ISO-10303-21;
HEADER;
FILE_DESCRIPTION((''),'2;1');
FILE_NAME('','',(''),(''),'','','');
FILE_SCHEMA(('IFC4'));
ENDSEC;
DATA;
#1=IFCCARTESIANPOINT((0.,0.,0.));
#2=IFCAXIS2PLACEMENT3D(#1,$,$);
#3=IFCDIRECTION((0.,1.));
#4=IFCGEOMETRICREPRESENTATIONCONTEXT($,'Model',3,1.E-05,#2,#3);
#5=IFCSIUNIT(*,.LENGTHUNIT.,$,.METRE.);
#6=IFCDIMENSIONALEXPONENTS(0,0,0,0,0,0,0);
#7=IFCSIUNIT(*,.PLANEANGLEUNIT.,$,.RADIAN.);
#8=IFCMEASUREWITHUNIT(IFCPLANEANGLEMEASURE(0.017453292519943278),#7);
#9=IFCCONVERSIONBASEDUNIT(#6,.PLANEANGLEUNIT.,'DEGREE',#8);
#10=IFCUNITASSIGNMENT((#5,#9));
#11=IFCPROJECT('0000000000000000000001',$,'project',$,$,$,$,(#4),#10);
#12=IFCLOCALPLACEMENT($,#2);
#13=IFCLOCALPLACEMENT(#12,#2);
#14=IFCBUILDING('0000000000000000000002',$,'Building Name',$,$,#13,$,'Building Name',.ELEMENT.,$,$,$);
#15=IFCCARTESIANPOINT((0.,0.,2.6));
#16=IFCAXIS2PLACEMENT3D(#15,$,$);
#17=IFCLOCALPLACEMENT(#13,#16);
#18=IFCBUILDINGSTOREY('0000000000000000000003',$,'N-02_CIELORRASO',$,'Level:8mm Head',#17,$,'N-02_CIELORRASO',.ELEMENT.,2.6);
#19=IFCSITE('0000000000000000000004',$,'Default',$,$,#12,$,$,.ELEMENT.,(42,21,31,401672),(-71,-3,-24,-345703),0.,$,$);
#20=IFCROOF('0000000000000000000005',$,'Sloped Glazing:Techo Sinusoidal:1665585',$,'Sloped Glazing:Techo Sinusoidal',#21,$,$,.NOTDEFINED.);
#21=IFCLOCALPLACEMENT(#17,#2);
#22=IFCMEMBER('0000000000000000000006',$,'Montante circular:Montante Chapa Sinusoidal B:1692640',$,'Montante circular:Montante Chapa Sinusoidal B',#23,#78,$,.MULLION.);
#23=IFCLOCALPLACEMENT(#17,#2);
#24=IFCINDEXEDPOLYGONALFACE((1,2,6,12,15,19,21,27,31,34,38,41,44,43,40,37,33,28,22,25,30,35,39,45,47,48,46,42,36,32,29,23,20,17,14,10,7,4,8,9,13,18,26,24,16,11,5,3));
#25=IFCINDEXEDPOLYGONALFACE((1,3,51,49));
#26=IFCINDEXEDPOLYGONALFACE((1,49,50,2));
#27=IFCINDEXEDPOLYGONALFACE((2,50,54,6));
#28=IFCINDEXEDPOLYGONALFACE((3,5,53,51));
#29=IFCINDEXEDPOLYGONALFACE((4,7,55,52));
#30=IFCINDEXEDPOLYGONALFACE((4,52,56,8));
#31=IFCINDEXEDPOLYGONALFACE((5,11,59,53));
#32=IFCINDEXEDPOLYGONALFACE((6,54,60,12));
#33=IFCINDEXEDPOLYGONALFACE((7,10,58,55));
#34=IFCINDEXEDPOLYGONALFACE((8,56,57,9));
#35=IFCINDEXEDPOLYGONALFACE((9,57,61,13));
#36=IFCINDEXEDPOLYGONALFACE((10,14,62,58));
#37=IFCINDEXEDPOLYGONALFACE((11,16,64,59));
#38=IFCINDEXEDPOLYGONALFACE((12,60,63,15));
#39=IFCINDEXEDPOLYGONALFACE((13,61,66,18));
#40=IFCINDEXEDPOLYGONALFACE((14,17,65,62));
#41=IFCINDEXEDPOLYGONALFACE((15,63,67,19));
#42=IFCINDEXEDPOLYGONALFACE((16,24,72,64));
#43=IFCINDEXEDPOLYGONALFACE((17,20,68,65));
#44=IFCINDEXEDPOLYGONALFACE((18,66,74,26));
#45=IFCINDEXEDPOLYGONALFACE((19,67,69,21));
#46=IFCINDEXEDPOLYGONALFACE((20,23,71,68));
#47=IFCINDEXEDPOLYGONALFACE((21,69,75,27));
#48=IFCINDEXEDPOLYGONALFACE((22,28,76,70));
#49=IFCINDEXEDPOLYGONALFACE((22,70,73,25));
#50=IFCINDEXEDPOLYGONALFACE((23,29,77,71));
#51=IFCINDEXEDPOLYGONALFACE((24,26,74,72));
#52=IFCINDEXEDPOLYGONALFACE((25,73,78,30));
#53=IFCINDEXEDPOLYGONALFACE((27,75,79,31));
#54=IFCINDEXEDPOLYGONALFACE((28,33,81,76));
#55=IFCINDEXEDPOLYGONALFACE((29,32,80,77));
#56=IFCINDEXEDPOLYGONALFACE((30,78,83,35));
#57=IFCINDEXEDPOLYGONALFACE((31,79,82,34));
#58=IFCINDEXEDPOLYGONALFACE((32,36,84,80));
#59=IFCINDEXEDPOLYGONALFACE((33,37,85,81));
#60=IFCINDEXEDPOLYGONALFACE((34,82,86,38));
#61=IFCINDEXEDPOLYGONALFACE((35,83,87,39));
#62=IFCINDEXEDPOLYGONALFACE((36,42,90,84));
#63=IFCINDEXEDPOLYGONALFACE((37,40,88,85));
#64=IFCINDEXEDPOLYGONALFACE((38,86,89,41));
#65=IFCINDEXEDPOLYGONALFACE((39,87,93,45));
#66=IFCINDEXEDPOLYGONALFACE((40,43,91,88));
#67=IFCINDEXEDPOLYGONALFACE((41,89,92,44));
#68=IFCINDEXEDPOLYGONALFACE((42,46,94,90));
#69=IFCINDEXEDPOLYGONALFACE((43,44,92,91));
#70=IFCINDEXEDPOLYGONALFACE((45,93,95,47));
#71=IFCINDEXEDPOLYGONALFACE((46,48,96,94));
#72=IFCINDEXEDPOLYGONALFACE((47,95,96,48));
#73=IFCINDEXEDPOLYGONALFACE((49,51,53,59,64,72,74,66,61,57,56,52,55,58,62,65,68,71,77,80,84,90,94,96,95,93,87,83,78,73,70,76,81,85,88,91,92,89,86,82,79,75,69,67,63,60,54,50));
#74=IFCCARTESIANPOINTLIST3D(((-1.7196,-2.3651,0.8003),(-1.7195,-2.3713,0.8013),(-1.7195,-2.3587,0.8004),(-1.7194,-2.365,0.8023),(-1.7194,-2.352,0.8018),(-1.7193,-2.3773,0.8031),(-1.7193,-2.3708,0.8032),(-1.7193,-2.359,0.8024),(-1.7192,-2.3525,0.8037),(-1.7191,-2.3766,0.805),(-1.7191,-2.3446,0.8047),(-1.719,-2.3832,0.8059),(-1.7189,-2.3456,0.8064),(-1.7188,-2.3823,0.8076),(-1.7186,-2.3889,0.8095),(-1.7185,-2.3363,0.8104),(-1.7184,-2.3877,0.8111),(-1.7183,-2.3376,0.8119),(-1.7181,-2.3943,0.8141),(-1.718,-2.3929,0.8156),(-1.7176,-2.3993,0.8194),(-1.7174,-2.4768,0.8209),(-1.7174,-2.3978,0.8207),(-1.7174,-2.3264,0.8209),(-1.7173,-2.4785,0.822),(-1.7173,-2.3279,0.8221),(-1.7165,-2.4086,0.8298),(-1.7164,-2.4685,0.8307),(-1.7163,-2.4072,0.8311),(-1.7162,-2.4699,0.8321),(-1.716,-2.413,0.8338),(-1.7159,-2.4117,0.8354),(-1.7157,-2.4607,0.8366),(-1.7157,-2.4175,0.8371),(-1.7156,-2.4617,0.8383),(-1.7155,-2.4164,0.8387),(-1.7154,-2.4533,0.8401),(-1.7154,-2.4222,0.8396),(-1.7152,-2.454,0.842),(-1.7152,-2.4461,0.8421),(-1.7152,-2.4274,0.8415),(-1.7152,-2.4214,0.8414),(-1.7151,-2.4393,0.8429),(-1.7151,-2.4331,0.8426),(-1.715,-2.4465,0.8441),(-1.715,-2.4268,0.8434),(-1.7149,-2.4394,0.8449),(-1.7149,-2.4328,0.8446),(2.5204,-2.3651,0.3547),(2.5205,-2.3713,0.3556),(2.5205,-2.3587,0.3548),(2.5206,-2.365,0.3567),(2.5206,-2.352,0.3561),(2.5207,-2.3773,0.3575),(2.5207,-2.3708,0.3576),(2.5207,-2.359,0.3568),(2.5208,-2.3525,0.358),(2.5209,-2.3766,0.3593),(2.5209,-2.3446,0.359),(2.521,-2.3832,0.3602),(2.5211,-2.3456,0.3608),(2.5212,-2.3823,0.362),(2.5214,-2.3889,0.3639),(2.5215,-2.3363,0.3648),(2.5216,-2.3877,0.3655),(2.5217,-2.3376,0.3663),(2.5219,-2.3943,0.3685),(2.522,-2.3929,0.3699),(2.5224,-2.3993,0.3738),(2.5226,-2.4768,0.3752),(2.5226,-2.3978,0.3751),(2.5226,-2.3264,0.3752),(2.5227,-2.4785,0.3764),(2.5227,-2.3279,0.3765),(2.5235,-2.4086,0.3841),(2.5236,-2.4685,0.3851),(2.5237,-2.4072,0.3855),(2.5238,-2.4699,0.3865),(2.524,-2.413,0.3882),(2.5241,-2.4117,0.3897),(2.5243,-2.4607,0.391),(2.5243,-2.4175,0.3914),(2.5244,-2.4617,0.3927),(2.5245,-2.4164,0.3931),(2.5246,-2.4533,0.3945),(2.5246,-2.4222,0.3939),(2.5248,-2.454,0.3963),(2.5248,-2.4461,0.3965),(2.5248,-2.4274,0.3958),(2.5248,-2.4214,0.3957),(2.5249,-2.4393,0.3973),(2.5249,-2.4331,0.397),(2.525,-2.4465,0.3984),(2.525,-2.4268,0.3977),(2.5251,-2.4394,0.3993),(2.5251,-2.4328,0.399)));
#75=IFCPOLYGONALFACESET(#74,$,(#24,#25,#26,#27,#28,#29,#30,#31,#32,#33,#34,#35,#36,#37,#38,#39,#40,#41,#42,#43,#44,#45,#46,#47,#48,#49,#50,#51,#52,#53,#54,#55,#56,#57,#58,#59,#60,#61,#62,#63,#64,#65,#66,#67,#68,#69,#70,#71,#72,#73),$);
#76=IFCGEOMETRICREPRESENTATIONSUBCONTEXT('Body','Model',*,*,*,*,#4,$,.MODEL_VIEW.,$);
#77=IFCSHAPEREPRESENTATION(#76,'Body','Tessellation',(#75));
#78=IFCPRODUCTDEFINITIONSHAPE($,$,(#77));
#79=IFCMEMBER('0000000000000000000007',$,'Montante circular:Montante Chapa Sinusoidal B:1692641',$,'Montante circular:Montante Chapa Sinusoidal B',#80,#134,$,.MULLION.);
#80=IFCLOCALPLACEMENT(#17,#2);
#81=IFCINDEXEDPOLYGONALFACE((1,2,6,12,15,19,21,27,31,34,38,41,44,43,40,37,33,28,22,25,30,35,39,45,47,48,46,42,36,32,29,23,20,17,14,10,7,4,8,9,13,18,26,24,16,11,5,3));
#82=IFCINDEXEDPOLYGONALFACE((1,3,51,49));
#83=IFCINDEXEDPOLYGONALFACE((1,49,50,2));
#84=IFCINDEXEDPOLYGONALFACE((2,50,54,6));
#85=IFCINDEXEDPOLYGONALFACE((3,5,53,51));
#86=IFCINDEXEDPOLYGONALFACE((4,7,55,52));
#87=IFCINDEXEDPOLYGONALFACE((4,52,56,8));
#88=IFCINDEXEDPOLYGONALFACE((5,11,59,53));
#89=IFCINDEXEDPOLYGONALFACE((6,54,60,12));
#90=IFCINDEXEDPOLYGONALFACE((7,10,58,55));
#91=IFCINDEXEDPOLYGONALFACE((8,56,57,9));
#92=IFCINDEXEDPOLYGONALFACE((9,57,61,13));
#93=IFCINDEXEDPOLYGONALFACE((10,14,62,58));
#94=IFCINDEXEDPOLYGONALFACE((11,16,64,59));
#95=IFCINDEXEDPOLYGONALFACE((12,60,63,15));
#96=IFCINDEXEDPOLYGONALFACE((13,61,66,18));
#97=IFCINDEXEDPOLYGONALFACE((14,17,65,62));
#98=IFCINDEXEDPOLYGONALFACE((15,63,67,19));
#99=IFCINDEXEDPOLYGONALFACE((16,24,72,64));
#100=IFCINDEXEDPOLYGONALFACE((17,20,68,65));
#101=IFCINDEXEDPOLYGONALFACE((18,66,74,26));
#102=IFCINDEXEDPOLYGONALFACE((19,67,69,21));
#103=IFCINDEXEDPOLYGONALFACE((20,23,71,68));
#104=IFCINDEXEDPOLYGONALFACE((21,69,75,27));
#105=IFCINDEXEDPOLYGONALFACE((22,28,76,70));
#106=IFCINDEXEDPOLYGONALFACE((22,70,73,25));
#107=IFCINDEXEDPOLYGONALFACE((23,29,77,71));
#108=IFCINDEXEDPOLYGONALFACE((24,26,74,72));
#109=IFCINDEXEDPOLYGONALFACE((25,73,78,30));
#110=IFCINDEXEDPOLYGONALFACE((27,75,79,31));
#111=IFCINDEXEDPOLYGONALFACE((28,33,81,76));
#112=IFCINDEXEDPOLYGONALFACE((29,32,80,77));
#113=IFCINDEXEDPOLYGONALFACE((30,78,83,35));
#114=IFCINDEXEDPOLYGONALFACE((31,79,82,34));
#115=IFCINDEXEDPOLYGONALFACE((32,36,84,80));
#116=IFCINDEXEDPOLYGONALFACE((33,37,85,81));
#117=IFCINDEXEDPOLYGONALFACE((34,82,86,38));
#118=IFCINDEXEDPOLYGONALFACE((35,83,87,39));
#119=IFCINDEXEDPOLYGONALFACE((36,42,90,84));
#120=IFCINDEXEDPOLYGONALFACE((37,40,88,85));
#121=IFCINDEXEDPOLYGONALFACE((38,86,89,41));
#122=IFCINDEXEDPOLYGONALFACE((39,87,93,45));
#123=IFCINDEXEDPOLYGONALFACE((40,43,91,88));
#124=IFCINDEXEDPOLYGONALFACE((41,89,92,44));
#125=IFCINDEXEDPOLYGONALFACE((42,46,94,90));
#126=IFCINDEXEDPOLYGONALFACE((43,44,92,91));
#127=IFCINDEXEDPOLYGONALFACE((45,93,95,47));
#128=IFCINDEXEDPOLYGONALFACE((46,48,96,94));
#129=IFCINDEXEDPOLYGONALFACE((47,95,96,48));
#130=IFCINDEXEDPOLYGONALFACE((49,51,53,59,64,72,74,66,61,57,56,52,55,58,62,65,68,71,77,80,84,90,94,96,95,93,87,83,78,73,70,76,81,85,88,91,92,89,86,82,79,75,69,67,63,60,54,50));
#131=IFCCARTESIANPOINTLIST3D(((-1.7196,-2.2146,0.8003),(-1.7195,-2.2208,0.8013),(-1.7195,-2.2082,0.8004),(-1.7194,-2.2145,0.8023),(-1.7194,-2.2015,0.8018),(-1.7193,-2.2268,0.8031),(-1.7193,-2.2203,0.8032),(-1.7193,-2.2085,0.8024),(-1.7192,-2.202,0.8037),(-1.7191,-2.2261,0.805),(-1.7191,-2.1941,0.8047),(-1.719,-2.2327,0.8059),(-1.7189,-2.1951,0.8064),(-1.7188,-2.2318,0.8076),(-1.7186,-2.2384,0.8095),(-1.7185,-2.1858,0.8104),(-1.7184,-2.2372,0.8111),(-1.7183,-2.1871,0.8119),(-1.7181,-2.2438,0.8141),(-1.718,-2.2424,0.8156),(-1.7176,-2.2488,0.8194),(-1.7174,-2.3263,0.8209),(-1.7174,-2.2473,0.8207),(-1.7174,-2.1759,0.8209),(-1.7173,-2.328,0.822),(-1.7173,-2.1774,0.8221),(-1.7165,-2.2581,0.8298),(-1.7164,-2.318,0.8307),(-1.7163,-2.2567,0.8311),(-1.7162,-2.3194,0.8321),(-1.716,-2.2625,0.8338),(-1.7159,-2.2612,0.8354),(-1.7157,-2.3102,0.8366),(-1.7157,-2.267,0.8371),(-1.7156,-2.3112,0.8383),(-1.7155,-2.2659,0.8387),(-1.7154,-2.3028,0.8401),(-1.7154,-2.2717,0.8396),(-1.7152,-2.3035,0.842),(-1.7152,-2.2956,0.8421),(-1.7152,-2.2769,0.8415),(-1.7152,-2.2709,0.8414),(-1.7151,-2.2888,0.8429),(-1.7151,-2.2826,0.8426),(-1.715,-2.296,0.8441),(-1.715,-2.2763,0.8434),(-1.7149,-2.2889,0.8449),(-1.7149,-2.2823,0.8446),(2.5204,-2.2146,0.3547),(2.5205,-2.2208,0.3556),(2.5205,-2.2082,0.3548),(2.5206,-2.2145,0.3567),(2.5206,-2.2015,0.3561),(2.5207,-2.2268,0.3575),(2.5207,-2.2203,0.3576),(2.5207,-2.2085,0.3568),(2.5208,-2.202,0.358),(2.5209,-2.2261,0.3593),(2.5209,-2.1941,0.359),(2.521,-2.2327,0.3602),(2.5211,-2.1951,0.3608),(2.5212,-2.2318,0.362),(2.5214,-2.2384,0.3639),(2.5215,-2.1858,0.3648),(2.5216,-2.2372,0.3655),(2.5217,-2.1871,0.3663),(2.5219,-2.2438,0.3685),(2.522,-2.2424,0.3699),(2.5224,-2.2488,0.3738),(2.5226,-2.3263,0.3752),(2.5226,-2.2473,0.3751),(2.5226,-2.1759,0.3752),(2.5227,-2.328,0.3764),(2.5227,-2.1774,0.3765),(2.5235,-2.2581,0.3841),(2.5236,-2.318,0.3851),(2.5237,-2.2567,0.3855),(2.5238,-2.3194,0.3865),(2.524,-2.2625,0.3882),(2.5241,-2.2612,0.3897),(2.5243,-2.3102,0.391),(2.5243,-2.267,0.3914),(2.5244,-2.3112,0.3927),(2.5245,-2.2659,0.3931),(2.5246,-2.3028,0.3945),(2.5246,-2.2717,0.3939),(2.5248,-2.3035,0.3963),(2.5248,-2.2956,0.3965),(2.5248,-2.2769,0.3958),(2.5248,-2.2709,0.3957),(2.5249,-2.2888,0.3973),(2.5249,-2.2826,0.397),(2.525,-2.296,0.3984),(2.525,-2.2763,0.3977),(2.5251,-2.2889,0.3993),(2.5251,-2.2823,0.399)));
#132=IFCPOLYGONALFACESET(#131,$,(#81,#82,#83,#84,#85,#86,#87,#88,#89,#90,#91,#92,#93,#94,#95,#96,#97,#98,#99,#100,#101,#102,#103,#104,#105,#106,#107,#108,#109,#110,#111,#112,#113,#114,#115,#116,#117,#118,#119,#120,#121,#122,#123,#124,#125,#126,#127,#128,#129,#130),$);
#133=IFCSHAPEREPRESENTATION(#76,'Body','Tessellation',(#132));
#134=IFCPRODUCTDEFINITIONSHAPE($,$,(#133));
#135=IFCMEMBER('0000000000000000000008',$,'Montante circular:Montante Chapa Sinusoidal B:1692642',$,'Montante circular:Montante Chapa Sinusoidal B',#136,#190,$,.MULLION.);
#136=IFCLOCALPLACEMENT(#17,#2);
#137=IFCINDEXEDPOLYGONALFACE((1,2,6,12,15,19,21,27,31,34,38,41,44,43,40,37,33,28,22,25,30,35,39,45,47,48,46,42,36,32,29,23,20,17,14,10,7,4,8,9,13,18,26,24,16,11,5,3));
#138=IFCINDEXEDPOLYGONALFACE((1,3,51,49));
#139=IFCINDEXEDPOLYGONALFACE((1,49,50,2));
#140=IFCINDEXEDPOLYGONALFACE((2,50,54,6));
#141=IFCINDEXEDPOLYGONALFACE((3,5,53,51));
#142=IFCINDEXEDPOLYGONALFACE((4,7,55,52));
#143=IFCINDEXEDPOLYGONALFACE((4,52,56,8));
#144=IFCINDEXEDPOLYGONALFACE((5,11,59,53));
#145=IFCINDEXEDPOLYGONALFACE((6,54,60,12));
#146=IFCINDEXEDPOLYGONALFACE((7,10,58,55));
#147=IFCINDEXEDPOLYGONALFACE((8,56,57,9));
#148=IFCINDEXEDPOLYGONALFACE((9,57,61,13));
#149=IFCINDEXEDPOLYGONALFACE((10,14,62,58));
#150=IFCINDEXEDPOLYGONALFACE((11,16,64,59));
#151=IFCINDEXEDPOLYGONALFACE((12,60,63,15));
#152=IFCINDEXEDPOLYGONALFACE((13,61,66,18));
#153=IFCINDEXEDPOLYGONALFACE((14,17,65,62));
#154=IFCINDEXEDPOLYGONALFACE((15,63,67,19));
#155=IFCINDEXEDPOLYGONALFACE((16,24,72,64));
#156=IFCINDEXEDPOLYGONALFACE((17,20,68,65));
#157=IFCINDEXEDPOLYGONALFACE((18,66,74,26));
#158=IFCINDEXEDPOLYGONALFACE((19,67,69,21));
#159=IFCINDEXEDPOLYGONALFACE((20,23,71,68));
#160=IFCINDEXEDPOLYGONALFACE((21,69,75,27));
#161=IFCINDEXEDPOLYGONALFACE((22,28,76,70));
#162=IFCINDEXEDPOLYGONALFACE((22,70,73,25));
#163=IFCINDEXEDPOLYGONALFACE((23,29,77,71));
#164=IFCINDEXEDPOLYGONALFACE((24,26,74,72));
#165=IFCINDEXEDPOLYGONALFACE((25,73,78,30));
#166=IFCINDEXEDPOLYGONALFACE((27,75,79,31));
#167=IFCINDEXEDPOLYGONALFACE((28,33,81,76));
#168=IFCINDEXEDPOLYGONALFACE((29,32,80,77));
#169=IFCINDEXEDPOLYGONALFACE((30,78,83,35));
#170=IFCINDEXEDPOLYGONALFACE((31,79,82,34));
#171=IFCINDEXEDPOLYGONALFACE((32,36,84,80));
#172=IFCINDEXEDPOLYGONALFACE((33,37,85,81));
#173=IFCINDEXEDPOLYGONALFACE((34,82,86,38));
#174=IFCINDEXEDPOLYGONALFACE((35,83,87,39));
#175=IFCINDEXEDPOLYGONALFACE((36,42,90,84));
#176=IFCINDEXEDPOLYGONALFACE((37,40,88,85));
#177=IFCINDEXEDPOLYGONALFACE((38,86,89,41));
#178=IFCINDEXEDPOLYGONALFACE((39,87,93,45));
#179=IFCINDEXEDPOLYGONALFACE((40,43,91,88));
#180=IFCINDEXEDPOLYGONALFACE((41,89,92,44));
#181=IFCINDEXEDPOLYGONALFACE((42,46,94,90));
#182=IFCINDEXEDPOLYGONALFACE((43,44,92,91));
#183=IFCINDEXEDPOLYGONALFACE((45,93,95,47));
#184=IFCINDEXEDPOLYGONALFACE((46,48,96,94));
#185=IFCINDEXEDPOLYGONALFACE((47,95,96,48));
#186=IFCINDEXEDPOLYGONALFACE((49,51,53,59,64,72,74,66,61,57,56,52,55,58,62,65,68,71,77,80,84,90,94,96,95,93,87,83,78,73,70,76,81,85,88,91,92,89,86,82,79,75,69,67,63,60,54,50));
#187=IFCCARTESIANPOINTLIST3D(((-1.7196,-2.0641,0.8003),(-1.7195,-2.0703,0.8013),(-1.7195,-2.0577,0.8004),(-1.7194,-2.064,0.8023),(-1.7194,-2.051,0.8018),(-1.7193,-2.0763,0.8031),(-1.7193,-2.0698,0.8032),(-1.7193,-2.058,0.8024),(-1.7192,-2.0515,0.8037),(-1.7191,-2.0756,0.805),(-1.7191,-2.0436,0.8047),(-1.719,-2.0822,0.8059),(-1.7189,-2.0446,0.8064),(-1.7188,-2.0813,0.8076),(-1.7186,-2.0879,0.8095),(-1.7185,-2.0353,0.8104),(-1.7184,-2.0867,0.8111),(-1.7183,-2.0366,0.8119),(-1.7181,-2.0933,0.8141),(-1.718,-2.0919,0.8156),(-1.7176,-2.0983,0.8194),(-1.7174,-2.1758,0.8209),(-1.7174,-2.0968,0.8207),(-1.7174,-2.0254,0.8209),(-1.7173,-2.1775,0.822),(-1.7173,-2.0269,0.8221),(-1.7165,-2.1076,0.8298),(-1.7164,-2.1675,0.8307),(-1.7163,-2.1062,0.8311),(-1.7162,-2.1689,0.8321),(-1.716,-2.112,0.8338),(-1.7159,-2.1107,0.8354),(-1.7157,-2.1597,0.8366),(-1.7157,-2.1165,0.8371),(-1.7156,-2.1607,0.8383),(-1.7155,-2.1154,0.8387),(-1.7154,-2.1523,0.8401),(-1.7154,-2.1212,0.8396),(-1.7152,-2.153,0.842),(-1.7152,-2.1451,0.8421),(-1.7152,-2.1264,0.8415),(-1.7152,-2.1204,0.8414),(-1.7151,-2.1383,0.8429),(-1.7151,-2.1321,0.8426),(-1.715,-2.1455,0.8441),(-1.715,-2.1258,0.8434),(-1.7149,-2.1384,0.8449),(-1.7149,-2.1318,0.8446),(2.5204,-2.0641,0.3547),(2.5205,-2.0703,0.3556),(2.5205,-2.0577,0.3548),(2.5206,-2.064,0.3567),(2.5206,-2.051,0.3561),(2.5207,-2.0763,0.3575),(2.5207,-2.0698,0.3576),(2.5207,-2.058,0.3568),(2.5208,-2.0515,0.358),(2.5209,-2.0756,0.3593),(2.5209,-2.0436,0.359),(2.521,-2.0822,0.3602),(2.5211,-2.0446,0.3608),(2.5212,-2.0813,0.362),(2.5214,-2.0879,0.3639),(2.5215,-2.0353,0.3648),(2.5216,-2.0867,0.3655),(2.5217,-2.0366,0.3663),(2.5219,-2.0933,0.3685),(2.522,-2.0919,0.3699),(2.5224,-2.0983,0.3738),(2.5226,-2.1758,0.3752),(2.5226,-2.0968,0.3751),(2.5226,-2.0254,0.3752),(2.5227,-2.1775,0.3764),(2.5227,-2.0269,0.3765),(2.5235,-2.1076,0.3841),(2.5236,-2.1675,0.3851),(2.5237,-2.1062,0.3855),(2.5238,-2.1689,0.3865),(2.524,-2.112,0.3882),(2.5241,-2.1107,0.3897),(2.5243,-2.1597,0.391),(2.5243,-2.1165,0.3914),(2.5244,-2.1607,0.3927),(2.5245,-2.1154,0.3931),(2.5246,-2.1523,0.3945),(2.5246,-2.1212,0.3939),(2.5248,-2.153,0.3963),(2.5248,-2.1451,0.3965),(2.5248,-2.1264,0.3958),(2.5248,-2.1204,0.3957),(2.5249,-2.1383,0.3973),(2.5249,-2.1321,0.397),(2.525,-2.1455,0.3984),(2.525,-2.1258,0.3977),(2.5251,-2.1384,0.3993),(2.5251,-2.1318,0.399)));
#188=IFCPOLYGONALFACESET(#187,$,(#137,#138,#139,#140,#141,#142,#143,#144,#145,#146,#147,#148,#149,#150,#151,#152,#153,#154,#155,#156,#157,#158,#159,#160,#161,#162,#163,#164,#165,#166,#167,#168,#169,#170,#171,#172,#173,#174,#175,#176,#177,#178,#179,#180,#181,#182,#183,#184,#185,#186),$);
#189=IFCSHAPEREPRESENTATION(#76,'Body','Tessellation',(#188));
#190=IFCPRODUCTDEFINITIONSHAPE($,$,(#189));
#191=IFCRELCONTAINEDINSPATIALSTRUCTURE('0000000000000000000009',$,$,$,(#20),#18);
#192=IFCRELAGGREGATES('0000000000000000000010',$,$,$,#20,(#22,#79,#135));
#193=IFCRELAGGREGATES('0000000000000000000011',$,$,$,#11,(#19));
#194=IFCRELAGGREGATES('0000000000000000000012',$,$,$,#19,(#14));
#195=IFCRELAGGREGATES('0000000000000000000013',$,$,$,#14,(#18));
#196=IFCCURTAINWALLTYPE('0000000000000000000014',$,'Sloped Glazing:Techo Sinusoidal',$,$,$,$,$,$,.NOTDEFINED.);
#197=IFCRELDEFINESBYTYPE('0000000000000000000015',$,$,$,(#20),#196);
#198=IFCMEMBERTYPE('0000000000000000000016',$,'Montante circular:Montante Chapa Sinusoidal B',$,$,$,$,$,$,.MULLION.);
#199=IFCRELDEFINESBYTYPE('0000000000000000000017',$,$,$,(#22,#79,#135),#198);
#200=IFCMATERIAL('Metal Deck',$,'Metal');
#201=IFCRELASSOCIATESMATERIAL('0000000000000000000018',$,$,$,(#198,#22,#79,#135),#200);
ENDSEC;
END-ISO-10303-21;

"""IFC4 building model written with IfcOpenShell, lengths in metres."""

from ifc_helpers import new_model, entity, si_unit, converted_unit, direction, frame, origin, place, context, subcontext, project, spatial, indexed_curve, outline, extrude, source, transform, mapped, material, type_object, type_shapes, element, aggregate, save


model = new_model("IFC4")

# Units and contexts
model_context = context("Model", 3, precision=1e-05, world=origin(), true_north=direction((0.0, 1.0)))
body_context = subcontext(model_context, "Body", "Model", "MODEL_VIEW")
ifc_project = project(units=[si_unit("LENGTHUNIT", "METRE"), converted_unit("PLANEANGLEUNIT", "DEGREE", entity("IfcPlaneAngleMeasure", 0.017453292519943278), si_unit("PLANEANGLEUNIT", "RADIAN"), dimensions=[0, 0, 0, 0, 0, 0, 0])], contexts=[model_context])

# Site, building, storey
site_placement = place(None, origin())
site = spatial("IfcSite", under=ifc_project, at=site_placement, Name="Default", CompositionType="ELEMENT", RefLatitude=(42, 21, 31, 401672), RefLongitude=(-71, -3, -24, -345703), RefElevation=0.0)
building_placement = place(site_placement, origin())
building = spatial("IfcBuilding", under=site, at=building_placement, Name="Building Name", LongName="Building Name", CompositionType="ELEMENT")
storey_placement = place(building_placement, frame((0.0, 0.0, 2.6)))
storey = spatial("IfcBuildingStorey", under=building, at=storey_placement, Name="N-02_CIELORRASO", ObjectType="Level:8mm Head", LongName="N-02_CIELORRASO", CompositionType="ELEMENT", Elevation=2.6)

# Roof, members
curtain_wall_type = type_object("IfcCurtainWallType", Name="Sloped Glazing:Techo Sinusoidal", PredefinedType="NOTDEFINED")
roof_placement = place(storey_placement, frame((0.0, 0.0, -2.6)))
roof = element("IfcRoof", 1, at=roof_placement, inside=storey, type_object=curtain_wall_type, Name="Sloped Glazing:Techo Sinusoidal:1665585", ObjectType="Sloped Glazing:Techo Sinusoidal", PredefinedType="NOTDEFINED")
ifc_material_1 = material(Name="Metal Deck", Category="Metal")
member_type = type_object("IfcMemberType", Name="Montante circular:Montante Chapa Sinusoidal B", PredefinedType="MULLION", material=ifc_material_1)
shared_shape_1 = source(origin(), body_context, "Body", "SweptSolid", [
    extrude(outline(indexed_curve([(0.0595, -0.0443), (0.0615, -0.0443), (0.0603, -0.031), (0.0572, -0.0213), (0.053, -0.0138), (0.0481, -0.0078), (0.0427, -0.003), (0.0372, 0.0005), (0.0315, 0.0029), (0.0259, 0.0044), (0.0203, 0.0051), (0.0146, 0.005), (0.0084, 0.0041), (-0.0053, 0.0009), (-0.0123, -0.0005), (-0.0191, -0.0012), (-0.0256, -0.001), (-0.0317, 0.0001), (-0.0375, 0.0019), (-0.0428, 0.0046), (-0.0477, 0.0081), (-0.0522, 0.0128), (-0.0563, 0.0191), (-0.0597, 0.0282), (-0.0617, 0.0421), (-0.0637, 0.042), (-0.0616, 0.0277), (-0.0581, 0.0182), (-0.0537, 0.0116), (-0.049, 0.0066), (-0.0438, 0.0028), (-0.0382, 0.0001), (-0.0322, -0.0019), (-0.0258, -0.003), (-0.019, -0.0032), (-0.012, -0.0025), (-0.0048, -0.0011), (0.0088, 0.0021), (0.0147, 0.003), (0.0202, 0.0031), (0.0255, 0.0024), (0.0309, 0.001), (0.0362, -0.0013), (0.0415, -0.0046), (0.0466, -0.0092), (0.0513, -0.0149), (0.0554, -0.0221), (0.0584, -0.0314), (0.0595, -0.0443)], self_intersect=False)), frame((-0.007, 0.0228, -4.2634), z_axis=(0.0, 0.0, 1.0), x_axis=(-0.819152, -0.573576, 0.0)), (0.0, 0.0, 1.0), 4.2634),
])
type_shapes(member_type, [shared_shape_1])
member_1_placement = place(roof_placement, frame((-1.7148, -2.3956, 3.4456), z_axis=(-0.994522, 0.0, 0.104528), x_axis=(0.0, 1.0, 0.0)))
member_1 = element("IfcMember", 2, at=member_1_placement, type_object=member_type, material=ifc_material_1, Name="Montante circular:Montante Chapa Sinusoidal B:1692640", ObjectType="Montante circular:Montante Chapa Sinusoidal B", PredefinedType="MULLION", context=body_context, shape_type="MappedRepresentation", body=[
    mapped(shared_shape_1, transform((0.0, 0.0, 0.0), scale=1.0)),
])
member_2_placement = place(roof_placement, frame((-1.7148, -2.2451, 3.4456), z_axis=(-0.994522, 0.0, 0.104528), x_axis=(0.0, 1.0, 0.0)))
member_2 = element("IfcMember", 3, at=member_2_placement, type_object=member_type, material=ifc_material_1, Name="Montante circular:Montante Chapa Sinusoidal B:1692641", ObjectType="Montante circular:Montante Chapa Sinusoidal B", PredefinedType="MULLION", context=body_context, shape_type="MappedRepresentation", body=[
    mapped(shared_shape_1, transform((0.0, 0.0, 0.0), scale=1.0)),
])
member_3_placement = place(roof_placement, frame((-1.7148, -2.0946, 3.4456), z_axis=(-0.994522, 0.0, 0.104528), x_axis=(0.0, 1.0, 0.0)))
member_3 = element("IfcMember", 4, at=member_3_placement, type_object=member_type, material=ifc_material_1, Name="Montante circular:Montante Chapa Sinusoidal B:1692642", ObjectType="Montante circular:Montante Chapa Sinusoidal B", PredefinedType="MULLION", context=body_context, shape_type="MappedRepresentation", body=[
    mapped(shared_shape_1, transform((0.0, 0.0, 0.0), scale=1.0)),
])
aggregate(roof, [member_1, member_2, member_3])

save(model, "model.ifc")
